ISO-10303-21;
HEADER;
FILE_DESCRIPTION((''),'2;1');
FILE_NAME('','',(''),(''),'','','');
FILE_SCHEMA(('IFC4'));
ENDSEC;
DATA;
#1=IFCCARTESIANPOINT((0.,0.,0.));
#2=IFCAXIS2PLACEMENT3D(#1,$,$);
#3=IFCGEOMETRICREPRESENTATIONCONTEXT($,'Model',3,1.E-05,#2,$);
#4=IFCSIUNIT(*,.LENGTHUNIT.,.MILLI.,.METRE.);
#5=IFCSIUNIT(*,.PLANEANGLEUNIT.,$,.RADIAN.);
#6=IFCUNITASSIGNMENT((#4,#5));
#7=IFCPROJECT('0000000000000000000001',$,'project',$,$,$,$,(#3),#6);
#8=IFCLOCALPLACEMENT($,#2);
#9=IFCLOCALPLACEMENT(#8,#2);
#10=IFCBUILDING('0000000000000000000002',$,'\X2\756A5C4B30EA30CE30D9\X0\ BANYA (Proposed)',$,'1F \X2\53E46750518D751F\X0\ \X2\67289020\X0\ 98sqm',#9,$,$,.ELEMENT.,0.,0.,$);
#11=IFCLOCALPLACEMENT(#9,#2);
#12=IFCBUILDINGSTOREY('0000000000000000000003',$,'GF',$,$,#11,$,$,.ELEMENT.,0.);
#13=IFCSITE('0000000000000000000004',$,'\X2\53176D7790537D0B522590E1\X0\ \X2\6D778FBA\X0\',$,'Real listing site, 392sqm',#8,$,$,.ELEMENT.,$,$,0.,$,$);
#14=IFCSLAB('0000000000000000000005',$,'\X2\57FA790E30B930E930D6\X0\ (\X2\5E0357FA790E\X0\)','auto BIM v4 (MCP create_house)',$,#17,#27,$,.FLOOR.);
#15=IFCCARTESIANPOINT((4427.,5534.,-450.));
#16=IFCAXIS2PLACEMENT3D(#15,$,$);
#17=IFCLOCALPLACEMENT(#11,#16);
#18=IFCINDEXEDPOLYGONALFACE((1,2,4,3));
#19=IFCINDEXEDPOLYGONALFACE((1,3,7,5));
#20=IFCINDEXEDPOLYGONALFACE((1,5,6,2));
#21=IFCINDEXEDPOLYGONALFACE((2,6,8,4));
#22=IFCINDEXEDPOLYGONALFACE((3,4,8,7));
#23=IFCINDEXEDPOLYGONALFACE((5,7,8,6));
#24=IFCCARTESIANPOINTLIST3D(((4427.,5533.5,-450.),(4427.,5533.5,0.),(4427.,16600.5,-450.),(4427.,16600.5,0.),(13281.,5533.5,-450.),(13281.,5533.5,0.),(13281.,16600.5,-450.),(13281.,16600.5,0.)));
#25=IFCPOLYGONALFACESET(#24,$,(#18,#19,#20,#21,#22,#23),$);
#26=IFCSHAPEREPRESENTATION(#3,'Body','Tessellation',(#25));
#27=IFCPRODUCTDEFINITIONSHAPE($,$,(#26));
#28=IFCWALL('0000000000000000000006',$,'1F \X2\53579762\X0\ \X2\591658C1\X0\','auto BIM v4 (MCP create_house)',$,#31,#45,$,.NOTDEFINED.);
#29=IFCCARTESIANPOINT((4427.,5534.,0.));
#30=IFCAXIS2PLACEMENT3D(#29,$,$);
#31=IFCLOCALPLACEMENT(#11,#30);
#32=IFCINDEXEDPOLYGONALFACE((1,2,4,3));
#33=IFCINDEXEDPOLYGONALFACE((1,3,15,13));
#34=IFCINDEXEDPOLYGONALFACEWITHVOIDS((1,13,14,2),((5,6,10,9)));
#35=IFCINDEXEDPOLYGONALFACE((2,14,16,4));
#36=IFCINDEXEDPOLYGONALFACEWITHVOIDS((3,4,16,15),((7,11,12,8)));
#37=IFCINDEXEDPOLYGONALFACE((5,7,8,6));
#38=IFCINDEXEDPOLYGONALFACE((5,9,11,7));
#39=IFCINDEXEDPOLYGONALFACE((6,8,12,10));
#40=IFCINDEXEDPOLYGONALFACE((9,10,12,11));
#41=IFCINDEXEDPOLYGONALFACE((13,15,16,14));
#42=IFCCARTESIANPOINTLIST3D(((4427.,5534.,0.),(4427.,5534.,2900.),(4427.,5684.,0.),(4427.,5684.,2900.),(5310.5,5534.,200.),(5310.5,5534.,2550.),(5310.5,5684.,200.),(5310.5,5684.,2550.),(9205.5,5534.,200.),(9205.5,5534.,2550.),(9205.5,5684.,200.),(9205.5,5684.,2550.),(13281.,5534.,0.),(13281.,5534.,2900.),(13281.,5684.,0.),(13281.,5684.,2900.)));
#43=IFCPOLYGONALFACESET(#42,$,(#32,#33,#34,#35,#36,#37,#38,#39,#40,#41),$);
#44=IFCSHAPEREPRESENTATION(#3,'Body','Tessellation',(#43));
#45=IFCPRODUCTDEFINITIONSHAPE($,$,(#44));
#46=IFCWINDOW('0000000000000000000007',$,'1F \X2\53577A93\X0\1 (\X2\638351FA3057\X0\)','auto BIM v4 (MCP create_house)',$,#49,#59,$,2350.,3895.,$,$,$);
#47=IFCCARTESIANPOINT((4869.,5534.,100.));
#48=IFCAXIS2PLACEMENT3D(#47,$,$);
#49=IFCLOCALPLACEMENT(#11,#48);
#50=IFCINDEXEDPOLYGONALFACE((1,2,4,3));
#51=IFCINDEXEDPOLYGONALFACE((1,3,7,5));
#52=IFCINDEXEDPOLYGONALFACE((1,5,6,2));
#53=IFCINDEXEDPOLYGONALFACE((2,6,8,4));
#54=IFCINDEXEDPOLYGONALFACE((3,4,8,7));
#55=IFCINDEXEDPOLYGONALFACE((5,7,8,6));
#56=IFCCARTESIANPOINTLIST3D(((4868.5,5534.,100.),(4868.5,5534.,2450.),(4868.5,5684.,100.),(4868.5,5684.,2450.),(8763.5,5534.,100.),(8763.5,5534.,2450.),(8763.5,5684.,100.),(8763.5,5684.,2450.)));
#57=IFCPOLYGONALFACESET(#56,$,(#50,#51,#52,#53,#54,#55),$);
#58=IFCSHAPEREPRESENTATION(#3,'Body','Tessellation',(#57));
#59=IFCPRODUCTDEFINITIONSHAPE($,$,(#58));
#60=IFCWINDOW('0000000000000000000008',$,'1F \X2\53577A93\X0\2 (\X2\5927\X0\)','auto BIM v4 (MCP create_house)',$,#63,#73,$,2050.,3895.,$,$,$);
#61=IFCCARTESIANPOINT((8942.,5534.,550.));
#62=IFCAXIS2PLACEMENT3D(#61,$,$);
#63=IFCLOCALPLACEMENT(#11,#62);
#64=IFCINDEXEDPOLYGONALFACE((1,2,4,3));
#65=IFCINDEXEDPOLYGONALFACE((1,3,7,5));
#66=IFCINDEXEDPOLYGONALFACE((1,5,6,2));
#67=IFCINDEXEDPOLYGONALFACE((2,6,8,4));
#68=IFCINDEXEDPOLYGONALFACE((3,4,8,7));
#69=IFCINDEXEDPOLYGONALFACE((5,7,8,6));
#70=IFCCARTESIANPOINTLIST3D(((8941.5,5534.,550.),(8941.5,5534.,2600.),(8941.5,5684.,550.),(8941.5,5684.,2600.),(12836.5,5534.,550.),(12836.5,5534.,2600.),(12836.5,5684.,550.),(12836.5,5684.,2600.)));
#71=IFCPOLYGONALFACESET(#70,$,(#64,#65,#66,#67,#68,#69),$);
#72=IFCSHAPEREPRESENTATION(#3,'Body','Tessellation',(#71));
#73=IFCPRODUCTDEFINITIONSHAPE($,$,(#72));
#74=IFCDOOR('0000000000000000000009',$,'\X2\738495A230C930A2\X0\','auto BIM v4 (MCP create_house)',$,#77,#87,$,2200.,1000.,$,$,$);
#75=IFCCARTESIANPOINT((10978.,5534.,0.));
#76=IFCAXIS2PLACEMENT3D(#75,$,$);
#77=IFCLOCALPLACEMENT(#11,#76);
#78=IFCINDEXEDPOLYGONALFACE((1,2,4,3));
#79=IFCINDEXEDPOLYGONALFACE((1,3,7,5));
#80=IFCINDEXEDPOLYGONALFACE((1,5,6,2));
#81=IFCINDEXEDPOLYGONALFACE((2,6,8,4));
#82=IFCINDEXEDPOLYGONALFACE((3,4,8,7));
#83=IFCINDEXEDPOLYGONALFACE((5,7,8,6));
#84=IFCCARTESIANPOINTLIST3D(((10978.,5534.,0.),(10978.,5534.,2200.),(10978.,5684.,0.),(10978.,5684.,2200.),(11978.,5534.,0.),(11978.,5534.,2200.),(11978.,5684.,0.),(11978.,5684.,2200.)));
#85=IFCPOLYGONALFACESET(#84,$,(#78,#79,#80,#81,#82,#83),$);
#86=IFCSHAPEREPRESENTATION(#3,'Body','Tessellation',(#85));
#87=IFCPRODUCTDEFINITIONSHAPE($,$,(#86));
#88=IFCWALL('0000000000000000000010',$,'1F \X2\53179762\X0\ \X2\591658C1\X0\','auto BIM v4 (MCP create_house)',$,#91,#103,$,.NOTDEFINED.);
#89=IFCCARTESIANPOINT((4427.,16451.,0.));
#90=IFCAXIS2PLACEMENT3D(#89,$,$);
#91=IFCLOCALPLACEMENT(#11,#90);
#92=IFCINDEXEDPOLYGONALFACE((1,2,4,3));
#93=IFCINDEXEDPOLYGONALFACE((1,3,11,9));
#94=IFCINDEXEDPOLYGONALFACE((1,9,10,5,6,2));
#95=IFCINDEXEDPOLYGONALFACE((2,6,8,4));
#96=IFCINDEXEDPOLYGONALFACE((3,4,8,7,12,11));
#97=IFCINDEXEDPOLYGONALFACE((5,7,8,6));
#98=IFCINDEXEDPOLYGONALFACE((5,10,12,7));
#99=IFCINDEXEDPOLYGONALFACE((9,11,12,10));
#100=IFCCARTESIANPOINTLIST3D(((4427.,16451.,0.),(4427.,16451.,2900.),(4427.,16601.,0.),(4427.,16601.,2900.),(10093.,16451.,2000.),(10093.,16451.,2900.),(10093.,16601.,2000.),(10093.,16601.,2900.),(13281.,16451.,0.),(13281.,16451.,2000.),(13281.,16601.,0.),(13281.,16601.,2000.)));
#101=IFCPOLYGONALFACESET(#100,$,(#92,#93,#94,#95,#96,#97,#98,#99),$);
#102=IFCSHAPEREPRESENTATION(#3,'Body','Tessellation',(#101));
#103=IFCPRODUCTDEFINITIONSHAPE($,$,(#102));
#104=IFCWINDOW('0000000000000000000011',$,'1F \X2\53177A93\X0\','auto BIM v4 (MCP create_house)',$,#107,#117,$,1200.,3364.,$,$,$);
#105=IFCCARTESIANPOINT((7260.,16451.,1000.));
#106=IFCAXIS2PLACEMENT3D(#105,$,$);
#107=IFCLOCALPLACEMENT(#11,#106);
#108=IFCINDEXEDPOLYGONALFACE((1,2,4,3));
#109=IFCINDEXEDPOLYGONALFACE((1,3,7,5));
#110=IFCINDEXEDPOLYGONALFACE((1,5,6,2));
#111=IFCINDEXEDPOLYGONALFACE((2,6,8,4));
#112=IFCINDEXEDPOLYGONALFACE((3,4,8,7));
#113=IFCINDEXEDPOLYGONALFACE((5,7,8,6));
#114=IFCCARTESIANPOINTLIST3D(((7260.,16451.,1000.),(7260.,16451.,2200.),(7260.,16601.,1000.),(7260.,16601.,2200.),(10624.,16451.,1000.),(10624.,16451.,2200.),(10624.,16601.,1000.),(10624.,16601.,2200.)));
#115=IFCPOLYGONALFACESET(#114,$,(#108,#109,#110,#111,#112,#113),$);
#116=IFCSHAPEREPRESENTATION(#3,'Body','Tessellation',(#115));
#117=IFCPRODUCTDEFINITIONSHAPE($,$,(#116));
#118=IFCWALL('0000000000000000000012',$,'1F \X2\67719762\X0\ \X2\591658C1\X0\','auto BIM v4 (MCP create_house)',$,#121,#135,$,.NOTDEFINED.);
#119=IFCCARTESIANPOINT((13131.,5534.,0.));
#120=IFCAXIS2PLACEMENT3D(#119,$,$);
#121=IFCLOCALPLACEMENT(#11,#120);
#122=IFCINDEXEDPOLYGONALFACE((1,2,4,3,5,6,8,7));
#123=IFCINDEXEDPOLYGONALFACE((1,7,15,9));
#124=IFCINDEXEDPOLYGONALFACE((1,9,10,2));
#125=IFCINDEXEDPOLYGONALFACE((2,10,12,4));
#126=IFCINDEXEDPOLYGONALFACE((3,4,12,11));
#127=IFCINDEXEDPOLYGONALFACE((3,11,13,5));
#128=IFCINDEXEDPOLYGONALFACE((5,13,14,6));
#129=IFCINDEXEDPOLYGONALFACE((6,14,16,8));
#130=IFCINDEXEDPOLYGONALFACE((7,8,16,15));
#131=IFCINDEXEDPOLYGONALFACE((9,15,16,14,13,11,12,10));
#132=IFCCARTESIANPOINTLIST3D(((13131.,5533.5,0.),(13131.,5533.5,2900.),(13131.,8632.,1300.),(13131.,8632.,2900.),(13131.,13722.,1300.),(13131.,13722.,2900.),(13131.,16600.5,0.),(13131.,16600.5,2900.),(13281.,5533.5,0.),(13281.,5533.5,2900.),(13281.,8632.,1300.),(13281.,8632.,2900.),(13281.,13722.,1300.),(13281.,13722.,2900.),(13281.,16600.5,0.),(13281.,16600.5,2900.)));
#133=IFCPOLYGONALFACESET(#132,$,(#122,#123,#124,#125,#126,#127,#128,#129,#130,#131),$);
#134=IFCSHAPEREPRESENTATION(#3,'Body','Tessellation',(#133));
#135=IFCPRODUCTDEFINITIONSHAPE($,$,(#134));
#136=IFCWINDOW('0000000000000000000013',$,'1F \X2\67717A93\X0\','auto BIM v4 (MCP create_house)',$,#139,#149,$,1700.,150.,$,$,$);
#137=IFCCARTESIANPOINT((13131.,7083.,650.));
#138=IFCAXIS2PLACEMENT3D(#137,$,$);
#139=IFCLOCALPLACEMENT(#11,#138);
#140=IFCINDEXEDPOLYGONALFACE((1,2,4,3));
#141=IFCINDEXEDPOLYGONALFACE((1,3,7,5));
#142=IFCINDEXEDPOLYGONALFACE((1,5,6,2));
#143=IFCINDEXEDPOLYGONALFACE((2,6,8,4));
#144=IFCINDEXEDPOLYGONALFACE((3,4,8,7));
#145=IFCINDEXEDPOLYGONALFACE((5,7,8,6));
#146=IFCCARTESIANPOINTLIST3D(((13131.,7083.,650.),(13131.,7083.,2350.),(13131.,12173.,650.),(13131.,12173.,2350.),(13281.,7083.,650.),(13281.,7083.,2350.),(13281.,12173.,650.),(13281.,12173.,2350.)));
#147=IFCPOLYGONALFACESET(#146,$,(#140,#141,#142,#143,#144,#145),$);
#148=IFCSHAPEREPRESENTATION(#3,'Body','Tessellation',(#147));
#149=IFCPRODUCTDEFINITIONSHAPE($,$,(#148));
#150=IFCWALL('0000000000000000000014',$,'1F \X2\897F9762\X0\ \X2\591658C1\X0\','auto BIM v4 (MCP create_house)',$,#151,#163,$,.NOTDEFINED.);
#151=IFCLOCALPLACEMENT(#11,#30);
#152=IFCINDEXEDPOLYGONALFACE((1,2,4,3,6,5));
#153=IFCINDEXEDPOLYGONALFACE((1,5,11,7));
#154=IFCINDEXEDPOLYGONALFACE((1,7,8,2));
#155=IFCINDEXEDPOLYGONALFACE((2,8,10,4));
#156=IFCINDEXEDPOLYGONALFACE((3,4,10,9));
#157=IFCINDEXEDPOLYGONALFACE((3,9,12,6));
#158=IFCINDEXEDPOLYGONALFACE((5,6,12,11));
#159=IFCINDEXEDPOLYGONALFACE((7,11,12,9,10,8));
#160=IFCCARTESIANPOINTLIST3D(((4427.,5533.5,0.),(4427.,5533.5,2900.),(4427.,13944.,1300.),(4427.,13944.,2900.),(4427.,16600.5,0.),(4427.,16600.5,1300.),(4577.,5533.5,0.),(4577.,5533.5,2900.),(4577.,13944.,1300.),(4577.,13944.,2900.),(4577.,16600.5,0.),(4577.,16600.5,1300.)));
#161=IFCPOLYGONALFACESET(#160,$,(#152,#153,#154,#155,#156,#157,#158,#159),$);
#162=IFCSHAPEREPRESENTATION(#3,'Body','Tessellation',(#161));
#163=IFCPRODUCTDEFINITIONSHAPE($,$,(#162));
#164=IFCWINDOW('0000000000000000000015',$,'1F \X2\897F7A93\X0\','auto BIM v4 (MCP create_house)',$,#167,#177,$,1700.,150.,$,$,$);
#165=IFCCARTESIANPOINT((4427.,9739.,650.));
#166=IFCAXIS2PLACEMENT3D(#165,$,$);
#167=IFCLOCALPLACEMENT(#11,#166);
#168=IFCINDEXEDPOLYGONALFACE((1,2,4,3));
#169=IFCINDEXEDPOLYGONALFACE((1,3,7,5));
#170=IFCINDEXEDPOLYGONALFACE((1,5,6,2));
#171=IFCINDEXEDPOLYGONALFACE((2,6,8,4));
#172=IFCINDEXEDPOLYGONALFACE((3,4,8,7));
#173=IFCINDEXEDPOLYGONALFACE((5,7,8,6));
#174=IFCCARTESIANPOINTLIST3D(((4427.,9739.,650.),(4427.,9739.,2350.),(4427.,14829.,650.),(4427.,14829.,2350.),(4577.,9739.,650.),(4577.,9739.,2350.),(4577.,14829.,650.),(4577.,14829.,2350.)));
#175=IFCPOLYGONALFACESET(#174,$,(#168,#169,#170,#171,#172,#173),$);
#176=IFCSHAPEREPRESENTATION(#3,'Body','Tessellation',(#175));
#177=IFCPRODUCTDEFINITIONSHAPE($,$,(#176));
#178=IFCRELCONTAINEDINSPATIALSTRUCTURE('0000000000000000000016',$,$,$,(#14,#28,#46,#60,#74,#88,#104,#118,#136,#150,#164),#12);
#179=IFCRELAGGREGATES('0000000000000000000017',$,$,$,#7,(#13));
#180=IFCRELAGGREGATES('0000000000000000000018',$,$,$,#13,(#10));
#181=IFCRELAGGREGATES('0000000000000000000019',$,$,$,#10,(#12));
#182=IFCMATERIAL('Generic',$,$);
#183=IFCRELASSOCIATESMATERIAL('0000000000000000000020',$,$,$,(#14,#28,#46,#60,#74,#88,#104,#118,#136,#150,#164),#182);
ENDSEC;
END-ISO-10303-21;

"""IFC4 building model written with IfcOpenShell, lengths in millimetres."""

from ifc_helpers import new_model, si_unit, frame, frame_2d, origin, place, context, project, spatial, rectangle, extrude, material, element, fill, save


model = new_model("IFC4")

# Units and contexts
model_context = context("Model", 3, precision=1e-05, world=origin())
ifc_project = project(units=[si_unit("LENGTHUNIT", "METRE", prefix="MILLI"), si_unit("PLANEANGLEUNIT", "RADIAN")], contexts=[model_context])

# Site, building, storey
site_placement = place(None, origin())
site = spatial("IfcSite", under=ifc_project, at=site_placement, Name="北海道紋別郡 海辺", ObjectType="Real listing site, 392sqm", CompositionType="ELEMENT", RefElevation=0.0)
building_placement = place(site_placement, origin())
building = spatial("IfcBuilding", under=site, at=building_placement, Name="番屋リノベ BANYA (Proposed)", ObjectType="1F 古材再生 木造 98sqm", CompositionType="ELEMENT", ElevationOfRefHeight=0.0, ElevationOfTerrain=0.0)
storey_placement = place(building_placement, origin())
storey = spatial("IfcBuildingStorey", under=building, at=storey_placement, Name="GF", CompositionType="ELEMENT", Elevation=0.0)

# Slab
ifc_material = material(Name="Generic")
slab_1_placement = place(storey_placement, frame((4427.0, 5534.0, -450.0)))
element("IfcSlab", 1, at=slab_1_placement, inside=storey, material=ifc_material, Name="基礎スラブ (布基礎)", Description="auto BIM v4 (MCP create_house)", PredefinedType="FLOOR", context=model_context, shape_type="SweptSolid", body=[
    extrude(rectangle(XDim=8854.0, YDim=11067.0, at=frame_2d((4427.0, 5533.0))), frame((4427.0, 5534.0, -450.0)), (0.0, 0.0, 1.0), 450.0),
])

# Wall, openings, windows, door
wall_1_placement = place(storey_placement, frame((4427.0, 5534.0, 0.0)))
wall_1 = element("IfcWall", 2, at=wall_1_placement, inside=storey, material=ifc_material, Name="1F 南面 外壁", Description="auto BIM v4 (MCP create_house)", PredefinedType="NOTDEFINED", context=model_context, shape_type="SweptSolid", body=[
    extrude(rectangle(XDim=8854.0, YDim=150.0, at=frame_2d((4427.0, 75.0))), frame((4427.0, 5534.0, 0.0)), (0.0, 0.0, 1.0), 2900.0),
])
opening_1_placement = place(storey_placement, frame((4869.0, 5534.0, 100.0)))
opening_1 = element("IfcOpeningElement", 3, at=opening_1_placement, cuts=wall_1, PredefinedType="NOTDEFINED", context=model_context, shape_type="SweptSolid", body=[
    extrude(rectangle(XDim=3895.0, YDim=150.0, at=frame_2d((1947.0, 75.0))), frame((4869.0, 5534.0, 100.0)), (0.0, 0.0, 1.0), 2350.0),
])
opening_2_placement = place(storey_placement, frame((8942.0, 5534.0, 550.0)))
opening_2 = element("IfcOpeningElement", 4, at=opening_2_placement, cuts=wall_1, PredefinedType="NOTDEFINED", context=model_context, shape_type="SweptSolid", body=[
    extrude(rectangle(XDim=3895.0, YDim=150.0, at=frame_2d((1947.0, 75.0))), frame((8942.0, 5534.0, 550.0)), (0.0, 0.0, 1.0), 2050.0),
])
opening_3_placement = place(storey_placement, frame((10978.0, 5534.0, 0.0)))
opening_3 = element("IfcOpeningElement", 5, at=opening_3_placement, cuts=wall_1, PredefinedType="NOTDEFINED", context=model_context, shape_type="SweptSolid", body=[
    extrude(rectangle(XDim=1000.0, YDim=150.0, at=frame_2d((500.0, 75.0))), frame((10978.0, 5534.0, 0.0)), (0.0, 0.0, 1.0), 2200.0),
])
window_1_placement = place(storey_placement, frame((4869.0, 5534.0, 100.0)))
window_1 = element("IfcWindow", 6, at=window_1_placement, inside=storey, material=ifc_material, Name="1F 南窓1 (掃出し)", Description="auto BIM v4 (MCP create_house)", OverallHeight=2350.0, OverallWidth=3895.0, context=model_context, shape_type="SweptSolid", body=[
    extrude(rectangle(XDim=3895.0, YDim=150.0, at=frame_2d((1947.0, 75.0))), frame((4869.0, 5534.0, 100.0)), (0.0, 0.0, 1.0), 2350.0),
])
fill(opening_1, window_1)
window_2_placement = place(storey_placement, frame((8942.0, 5534.0, 550.0)))
window_2 = element("IfcWindow", 7, at=window_2_placement, inside=storey, material=ifc_material, Name="1F 南窓2 (大)", Description="auto BIM v4 (MCP create_house)", OverallHeight=2050.0, OverallWidth=3895.0, context=model_context, shape_type="SweptSolid", body=[
    extrude(rectangle(XDim=3895.0, YDim=150.0, at=frame_2d((1947.0, 75.0))), frame((8942.0, 5534.0, 550.0)), (0.0, 0.0, 1.0), 2050.0),
])
fill(opening_2, window_2)
door_placement = place(storey_placement, frame((10978.0, 5534.0, 0.0)))
door = element("IfcDoor", 8, at=door_placement, inside=storey, material=ifc_material, Name="玄関ドア", Description="auto BIM v4 (MCP create_house)", OverallHeight=2200.0, OverallWidth=1000.0, context=model_context, shape_type="SweptSolid", body=[
    extrude(rectangle(XDim=1000.0, YDim=150.0, at=frame_2d((500.0, 75.0))), frame((10978.0, 5534.0, 0.0)), (0.0, 0.0, 1.0), 2200.0),
])
fill(opening_3, door)

# Walls, openings, windows
wall_2_placement = place(storey_placement, frame((4427.0, 16451.0, 0.0)))
wall_2 = element("IfcWall", 9, at=wall_2_placement, inside=storey, material=ifc_material, Name="1F 北面 外壁", Description="auto BIM v4 (MCP create_house)", PredefinedType="NOTDEFINED", context=model_context, shape_type="SweptSolid", body=[
    extrude(rectangle(XDim=8854.0, YDim=150.0, at=frame_2d((4427.0, 75.0))), frame((4427.0, 16451.0, 0.0)), (0.0, 0.0, 1.0), 2900.0),
])
opening_4_placement = place(storey_placement, frame((7260.0, 16451.0, 1000.0)))
opening_4 = element("IfcOpeningElement", 10, at=opening_4_placement, cuts=wall_2, PredefinedType="NOTDEFINED", context=model_context, shape_type="SweptSolid", body=[
    extrude(rectangle(XDim=3364.0, YDim=150.0, at=frame_2d((1682.0, 75.0))), frame((7260.0, 16451.0, 1000.0)), (0.0, 0.0, 1.0), 1200.0),
])
window_3_placement = place(storey_placement, frame((7260.0, 16451.0, 1000.0)))
window_3 = element("IfcWindow", 11, at=window_3_placement, inside=storey, material=ifc_material, Name="1F 北窓", Description="auto BIM v4 (MCP create_house)", OverallHeight=1200.0, OverallWidth=3364.0, context=model_context, shape_type="SweptSolid", body=[
    extrude(rectangle(XDim=3364.0, YDim=150.0, at=frame_2d((1682.0, 75.0))), frame((7260.0, 16451.0, 1000.0)), (0.0, 0.0, 1.0), 1200.0),
])
fill(opening_4, window_3)
wall_3_placement = place(storey_placement, frame((13131.0, 5534.0, 0.0)))
wall_3 = element("IfcWall", 12, at=wall_3_placement, inside=storey, material=ifc_material, Name="1F 東面 外壁", Description="auto BIM v4 (MCP create_house)", PredefinedType="NOTDEFINED", context=model_context, shape_type="SweptSolid", body=[
    extrude(rectangle(XDim=150.0, YDim=11067.0, at=frame_2d((75.0, 5533.0))), frame((13131.0, 5534.0, 0.0)), (0.0, 0.0, 1.0), 2900.0),
])
opening_5_placement = place(storey_placement, frame((13131.0, 7083.0, 650.0)))
opening_5 = element("IfcOpeningElement", 13, at=opening_5_placement, cuts=wall_3, PredefinedType="NOTDEFINED", context=model_context, shape_type="SweptSolid", body=[
    extrude(rectangle(XDim=150.0, YDim=5090.0, at=frame_2d((75.0, 2545.0))), frame((13131.0, 7083.0, 650.0)), (0.0, 0.0, 1.0), 1700.0),
])
window_4_placement = place(storey_placement, frame((13131.0, 7083.0, 650.0)))
window_4 = element("IfcWindow", 14, at=window_4_placement, inside=storey, material=ifc_material, Name="1F 東窓", Description="auto BIM v4 (MCP create_house)", OverallHeight=1700.0, OverallWidth=150.0, context=model_context, shape_type="SweptSolid", body=[
    extrude(rectangle(XDim=150.0, YDim=5090.0, at=frame_2d((75.0, 2545.0))), frame((13131.0, 7083.0, 650.0)), (0.0, 0.0, 1.0), 1700.0),
])
fill(opening_5, window_4)
wall_4_placement = place(storey_placement, frame((4427.0, 5534.0, 0.0)))
wall_4 = element("IfcWall", 15, at=wall_4_placement, inside=storey, material=ifc_material, Name="1F 西面 外壁", Description="auto BIM v4 (MCP create_house)", PredefinedType="NOTDEFINED", context=model_context, shape_type="SweptSolid", body=[
    extrude(rectangle(XDim=150.0, YDim=11067.0, at=frame_2d((75.0, 5533.0))), frame((4427.0, 5534.0, 0.0)), (0.0, 0.0, 1.0), 2900.0),
])
opening_6_placement = place(storey_placement, frame((4427.0, 9739.0, 650.0)))
opening_6 = element("IfcOpeningElement", 16, at=opening_6_placement, cuts=wall_4, PredefinedType="NOTDEFINED", context=model_context, shape_type="SweptSolid", body=[
    extrude(rectangle(XDim=150.0, YDim=5090.0, at=frame_2d((75.0, 2545.0))), frame((4427.0, 9739.0, 650.0)), (0.0, 0.0, 1.0), 1700.0),
])
window_5_placement = place(storey_placement, frame((4427.0, 9739.0, 650.0)))
window_5 = element("IfcWindow", 17, at=window_5_placement, inside=storey, material=ifc_material, Name="1F 西窓", Description="auto BIM v4 (MCP create_house)", OverallHeight=1700.0, OverallWidth=150.0, context=model_context, shape_type="SweptSolid", body=[
    extrude(rectangle(XDim=150.0, YDim=5090.0, at=frame_2d((75.0, 2545.0))), frame((4427.0, 9739.0, 650.0)), (0.0, 0.0, 1.0), 1700.0),
])
fill(opening_6, window_5)

save(model, "model.ifc")
